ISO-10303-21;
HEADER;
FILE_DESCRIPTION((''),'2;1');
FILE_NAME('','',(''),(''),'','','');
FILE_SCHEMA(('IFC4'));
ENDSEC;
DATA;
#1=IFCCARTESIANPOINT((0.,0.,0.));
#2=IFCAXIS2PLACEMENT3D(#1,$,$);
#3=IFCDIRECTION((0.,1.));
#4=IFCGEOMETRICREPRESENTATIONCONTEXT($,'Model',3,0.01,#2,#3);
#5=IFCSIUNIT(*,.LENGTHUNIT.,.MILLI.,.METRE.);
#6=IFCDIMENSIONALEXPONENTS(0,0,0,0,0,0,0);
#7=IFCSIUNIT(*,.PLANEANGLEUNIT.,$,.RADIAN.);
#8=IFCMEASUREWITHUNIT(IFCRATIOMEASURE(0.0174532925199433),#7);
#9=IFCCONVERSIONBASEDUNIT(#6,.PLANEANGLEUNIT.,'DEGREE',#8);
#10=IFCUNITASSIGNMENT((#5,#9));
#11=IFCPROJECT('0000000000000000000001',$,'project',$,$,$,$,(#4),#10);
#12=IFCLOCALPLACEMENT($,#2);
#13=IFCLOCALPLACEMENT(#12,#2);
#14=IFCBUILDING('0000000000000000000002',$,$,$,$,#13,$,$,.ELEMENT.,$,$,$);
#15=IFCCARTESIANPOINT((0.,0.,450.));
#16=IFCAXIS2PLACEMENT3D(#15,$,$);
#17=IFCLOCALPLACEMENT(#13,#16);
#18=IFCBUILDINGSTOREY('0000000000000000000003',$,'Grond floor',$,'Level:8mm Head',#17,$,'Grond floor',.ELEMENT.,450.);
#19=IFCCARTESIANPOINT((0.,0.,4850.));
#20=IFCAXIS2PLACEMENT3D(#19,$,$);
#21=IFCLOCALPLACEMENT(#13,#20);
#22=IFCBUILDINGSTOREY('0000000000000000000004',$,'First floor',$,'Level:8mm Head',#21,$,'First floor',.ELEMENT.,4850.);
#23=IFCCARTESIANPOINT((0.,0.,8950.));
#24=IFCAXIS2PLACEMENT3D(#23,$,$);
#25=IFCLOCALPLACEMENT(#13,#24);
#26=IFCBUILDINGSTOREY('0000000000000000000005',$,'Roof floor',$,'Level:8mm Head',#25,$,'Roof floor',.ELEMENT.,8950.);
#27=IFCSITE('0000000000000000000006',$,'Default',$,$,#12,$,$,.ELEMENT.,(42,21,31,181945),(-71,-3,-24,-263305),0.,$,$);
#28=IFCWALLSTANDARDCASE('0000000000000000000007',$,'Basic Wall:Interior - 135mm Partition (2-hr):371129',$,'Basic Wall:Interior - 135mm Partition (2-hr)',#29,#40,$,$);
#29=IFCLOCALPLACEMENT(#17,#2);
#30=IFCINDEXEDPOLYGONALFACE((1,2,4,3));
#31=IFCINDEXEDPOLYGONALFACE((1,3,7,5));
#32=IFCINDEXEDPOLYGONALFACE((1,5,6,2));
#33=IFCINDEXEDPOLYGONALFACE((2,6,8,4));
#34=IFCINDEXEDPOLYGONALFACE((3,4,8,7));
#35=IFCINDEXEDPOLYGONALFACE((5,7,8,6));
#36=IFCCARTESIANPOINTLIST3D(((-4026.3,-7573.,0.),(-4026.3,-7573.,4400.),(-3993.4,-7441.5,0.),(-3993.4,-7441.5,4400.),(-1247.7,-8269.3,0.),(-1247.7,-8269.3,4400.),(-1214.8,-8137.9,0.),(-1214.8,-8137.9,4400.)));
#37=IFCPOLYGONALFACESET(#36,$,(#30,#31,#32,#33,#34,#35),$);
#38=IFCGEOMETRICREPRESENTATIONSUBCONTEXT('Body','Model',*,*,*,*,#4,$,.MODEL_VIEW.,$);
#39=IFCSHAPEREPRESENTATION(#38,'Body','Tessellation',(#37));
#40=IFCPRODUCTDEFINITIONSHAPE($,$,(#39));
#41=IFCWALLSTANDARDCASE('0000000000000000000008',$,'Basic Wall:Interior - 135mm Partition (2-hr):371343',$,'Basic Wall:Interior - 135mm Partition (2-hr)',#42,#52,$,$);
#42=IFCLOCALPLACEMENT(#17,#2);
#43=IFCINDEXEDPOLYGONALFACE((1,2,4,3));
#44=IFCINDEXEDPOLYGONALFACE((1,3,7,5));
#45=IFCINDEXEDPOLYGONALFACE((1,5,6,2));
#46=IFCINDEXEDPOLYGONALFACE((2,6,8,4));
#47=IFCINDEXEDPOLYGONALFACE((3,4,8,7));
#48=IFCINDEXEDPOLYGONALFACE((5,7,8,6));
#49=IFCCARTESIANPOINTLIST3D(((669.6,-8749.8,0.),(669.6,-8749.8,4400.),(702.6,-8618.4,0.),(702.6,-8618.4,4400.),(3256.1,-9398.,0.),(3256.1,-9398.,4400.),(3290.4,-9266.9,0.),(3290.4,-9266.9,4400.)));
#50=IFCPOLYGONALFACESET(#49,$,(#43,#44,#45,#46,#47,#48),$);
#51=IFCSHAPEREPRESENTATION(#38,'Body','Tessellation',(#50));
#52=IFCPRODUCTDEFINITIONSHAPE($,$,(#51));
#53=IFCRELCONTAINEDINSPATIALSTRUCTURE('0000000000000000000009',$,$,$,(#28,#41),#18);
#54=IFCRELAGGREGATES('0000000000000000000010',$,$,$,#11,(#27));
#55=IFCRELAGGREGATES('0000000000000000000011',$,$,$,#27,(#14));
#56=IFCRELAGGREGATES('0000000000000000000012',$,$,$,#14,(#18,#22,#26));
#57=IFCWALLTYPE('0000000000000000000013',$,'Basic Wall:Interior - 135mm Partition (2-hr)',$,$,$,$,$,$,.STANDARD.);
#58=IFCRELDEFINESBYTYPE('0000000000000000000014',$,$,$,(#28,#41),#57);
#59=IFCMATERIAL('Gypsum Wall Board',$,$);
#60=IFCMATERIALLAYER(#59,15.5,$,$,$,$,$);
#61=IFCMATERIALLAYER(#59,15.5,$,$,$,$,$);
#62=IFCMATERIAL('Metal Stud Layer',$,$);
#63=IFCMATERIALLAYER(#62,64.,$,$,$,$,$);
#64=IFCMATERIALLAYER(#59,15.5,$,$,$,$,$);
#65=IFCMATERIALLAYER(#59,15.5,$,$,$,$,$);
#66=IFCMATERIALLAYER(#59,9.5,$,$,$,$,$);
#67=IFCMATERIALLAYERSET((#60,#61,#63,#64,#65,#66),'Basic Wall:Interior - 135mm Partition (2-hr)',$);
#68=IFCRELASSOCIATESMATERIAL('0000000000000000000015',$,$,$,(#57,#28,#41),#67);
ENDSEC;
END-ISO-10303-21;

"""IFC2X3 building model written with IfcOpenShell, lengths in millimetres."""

from ifc_helpers import new_model, entity, si_unit, converted_unit, direction, frame, frame_2d, origin, place, context, subcontext, project, spatial, polyline, rectangle, outline, extrude, material, layer, layer_set, layer_usage, type_object, element, save


model = new_model("IFC2X3")

# Units and contexts
model_context = context("Model", 3, precision=0.01, world=origin(), true_north=direction((0.0, 1.0)))
body_context = subcontext(model_context, "Body", "Model", "MODEL_VIEW")
ifc_project = project(units=[si_unit("LENGTHUNIT", "METRE", prefix="MILLI"), converted_unit("PLANEANGLEUNIT", "DEGREE", entity("IfcRatioMeasure", 0.0174532925199433), si_unit("PLANEANGLEUNIT", "RADIAN"), dimensions=[0, 0, 0, 0, 0, 0, 0])], contexts=[model_context])

# Site, building, storey
site_placement = place(None, origin())
site = spatial("IfcSite", under=ifc_project, at=site_placement, Name="Default", CompositionType="ELEMENT", RefLatitude=(42, 21, 31, 181945), RefLongitude=(-71, -3, -24, -263305), RefElevation=0.0)
building_placement = place(site_placement, origin())
building = spatial("IfcBuilding", under=site, at=building_placement, CompositionType="ELEMENT")
storey_1_placement = place(building_placement, frame((0.0, 0.0, 450.0)))
storey_1 = spatial("IfcBuildingStorey", under=building, at=storey_1_placement, Name="Grond floor", ObjectType="Level:8mm Head", LongName="Grond floor", CompositionType="ELEMENT", Elevation=450.0)

# Shared definitions
ifc_material_1 = material(Name="Gypsum Wall Board")

# Walls
ifc_layer_1 = layer(ifc_material_1, 15.5)
ifc_layer_2 = layer(ifc_material_1, 15.5)
ifc_material_2 = material(Name="Metal Stud Layer")
ifc_layer_3 = layer(ifc_material_2, 64.0)
ifc_layer_4 = layer(ifc_material_1, 15.5)
ifc_layer_5 = layer(ifc_material_1, 15.5)
ifc_layer_6 = layer(ifc_material_1, 9.5)
ifc_layer_set_1 = layer_set([ifc_layer_1, ifc_layer_2, ifc_layer_3, ifc_layer_4, ifc_layer_5, ifc_layer_6], Name="Basic Wall:Interior - 135mm Partition (2-hr)")
ifc_layer_usage_1 = layer_usage(ifc_layer_set_1, "AXIS2", "NEGATIVE", 67.8)
wall_type_1 = type_object("IfcWallType", Name="Basic Wall:Interior - 135mm Partition (2-hr)", PredefinedType="STANDARD", material=ifc_layer_set_1)
wall_1_placement = place(storey_1_placement, frame((-4009.9, -7507.3, 0.0), z_axis=(0.0, 0.0, 1.0), x_axis=(0.970003, -0.243092, 0.0)))
element("IfcWallStandardCase", 1, at=wall_1_placement, inside=storey_1, type_object=wall_type_1, material=ifc_layer_usage_1, Name="Basic Wall:Interior - 135mm Partition (2-hr):371129", ObjectType="Basic Wall:Interior - 135mm Partition (2-hr)", context=body_context, shape_type="SweptSolid", body=[
    extrude(rectangle(XDim=2864.5, YDim=135.5, at=frame_2d((1432.2, 0.0), x_axis=(-1.0, 0.0))), origin(), (0.0, 0.0, 1.0), 4400.0),
])
ifc_layer_usage_2 = layer_usage(ifc_layer_set_1, "AXIS2", "NEGATIVE", 67.8)
wall_2_placement = place(storey_1_placement, frame((686.1, -8684.1, 0.0), z_axis=(0.0, 0.0, 1.0), x_axis=(0.970003, -0.243092, 0.0)))
element("IfcWallStandardCase", 2, at=wall_2_placement, inside=storey_1, type_object=wall_type_1, material=ifc_layer_usage_2, Name="Basic Wall:Interior - 135mm Partition (2-hr):371343", ObjectType="Basic Wall:Interior - 135mm Partition (2-hr)", context=body_context, shape_type="SweptSolid", body=[
    extrude(outline(polyline([(2666.5, -67.8), (2667.8, 67.7), (0.0, 67.7), (0.0, -67.8), (2666.5, -67.8)])), origin(), (0.0, 0.0, 1.0), 4400.0),
])

# Shared definitions
storey_2_placement = place(building_placement, frame((0.0, 0.0, 4850.0)))
storey_2 = spatial("IfcBuildingStorey", under=building, at=storey_2_placement, Name="First floor", ObjectType="Level:8mm Head", LongName="First floor", CompositionType="ELEMENT", Elevation=4850.0)

# Shared definitions
storey_3_placement = place(building_placement, frame((0.0, 0.0, 8950.0)))
storey_3 = spatial("IfcBuildingStorey", under=building, at=storey_3_placement, Name="Roof floor", ObjectType="Level:8mm Head", LongName="Roof floor", CompositionType="ELEMENT", Elevation=8950.0)

save(model, "model.ifc")
